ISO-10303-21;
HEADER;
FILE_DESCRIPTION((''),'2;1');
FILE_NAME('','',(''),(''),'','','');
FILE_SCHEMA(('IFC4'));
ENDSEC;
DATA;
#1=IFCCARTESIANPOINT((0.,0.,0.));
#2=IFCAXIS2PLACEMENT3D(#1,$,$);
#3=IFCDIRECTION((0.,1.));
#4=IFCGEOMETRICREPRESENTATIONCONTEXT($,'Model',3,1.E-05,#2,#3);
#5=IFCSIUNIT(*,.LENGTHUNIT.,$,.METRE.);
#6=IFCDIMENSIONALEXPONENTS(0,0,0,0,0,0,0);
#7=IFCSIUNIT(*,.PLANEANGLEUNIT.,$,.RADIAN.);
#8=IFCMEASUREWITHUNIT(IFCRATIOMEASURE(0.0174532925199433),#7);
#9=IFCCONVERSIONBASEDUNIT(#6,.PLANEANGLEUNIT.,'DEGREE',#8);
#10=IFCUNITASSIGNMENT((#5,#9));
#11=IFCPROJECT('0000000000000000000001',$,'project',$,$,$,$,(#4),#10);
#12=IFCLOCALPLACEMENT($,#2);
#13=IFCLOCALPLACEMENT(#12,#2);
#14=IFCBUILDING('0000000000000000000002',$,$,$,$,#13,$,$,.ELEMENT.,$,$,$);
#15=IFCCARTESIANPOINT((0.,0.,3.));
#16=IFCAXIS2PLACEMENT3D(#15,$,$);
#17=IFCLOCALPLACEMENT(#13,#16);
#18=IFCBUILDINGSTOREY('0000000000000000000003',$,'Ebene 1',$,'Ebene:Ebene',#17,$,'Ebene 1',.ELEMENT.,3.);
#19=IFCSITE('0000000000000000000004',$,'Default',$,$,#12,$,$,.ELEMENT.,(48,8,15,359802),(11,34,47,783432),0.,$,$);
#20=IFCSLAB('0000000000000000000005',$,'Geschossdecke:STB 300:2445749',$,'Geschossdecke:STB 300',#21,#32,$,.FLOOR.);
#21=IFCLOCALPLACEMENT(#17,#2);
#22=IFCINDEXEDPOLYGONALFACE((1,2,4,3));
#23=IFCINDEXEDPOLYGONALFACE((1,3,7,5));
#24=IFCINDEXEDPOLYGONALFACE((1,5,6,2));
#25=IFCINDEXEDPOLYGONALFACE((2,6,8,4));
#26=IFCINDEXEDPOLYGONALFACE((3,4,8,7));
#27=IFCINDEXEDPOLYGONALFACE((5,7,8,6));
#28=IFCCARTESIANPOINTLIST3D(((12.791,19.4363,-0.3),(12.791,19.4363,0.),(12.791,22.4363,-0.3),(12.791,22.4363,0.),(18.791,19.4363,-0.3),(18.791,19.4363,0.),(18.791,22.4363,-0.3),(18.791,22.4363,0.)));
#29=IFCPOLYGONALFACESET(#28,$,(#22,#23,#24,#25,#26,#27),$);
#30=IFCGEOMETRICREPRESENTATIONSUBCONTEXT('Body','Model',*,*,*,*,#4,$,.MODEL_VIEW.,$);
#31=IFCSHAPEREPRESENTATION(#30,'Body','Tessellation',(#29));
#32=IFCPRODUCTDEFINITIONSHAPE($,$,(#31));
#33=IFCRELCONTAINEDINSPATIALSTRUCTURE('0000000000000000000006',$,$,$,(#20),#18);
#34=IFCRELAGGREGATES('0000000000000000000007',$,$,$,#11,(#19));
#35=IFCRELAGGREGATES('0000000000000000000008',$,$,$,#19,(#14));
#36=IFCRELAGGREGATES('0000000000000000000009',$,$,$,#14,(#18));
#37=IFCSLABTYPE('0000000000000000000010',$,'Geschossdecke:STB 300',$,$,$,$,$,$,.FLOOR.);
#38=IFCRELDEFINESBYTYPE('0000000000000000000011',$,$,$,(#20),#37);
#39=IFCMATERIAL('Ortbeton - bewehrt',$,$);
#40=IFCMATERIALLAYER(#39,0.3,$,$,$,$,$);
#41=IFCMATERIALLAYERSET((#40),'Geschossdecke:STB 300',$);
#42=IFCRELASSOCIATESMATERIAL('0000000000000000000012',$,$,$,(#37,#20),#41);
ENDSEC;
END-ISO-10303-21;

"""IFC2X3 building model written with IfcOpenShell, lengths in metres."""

from ifc_helpers import new_model, entity, si_unit, converted_unit, direction, frame, frame_2d, origin, place, context, subcontext, project, spatial, rectangle, extrude, material, layer, layer_set, layer_usage, type_object, element, save


model = new_model("IFC2X3")

# Units and contexts
model_context = context("Model", 3, precision=1e-05, world=origin(), true_north=direction((0.0, 1.0)))
body_context = subcontext(model_context, "Body", "Model", "MODEL_VIEW")
ifc_project = project(units=[si_unit("LENGTHUNIT", "METRE"), converted_unit("PLANEANGLEUNIT", "DEGREE", entity("IfcRatioMeasure", 0.0174532925199433), si_unit("PLANEANGLEUNIT", "RADIAN"), dimensions=[0, 0, 0, 0, 0, 0, 0])], contexts=[model_context])

# Site, building, storey
site_placement = place(None, origin())
site = spatial("IfcSite", under=ifc_project, at=site_placement, Name="Default", CompositionType="ELEMENT", RefLatitude=(48, 8, 15, 359802), RefLongitude=(11, 34, 47, 783432), RefElevation=0.0)
building_placement = place(site_placement, origin())
building = spatial("IfcBuilding", under=site, at=building_placement, CompositionType="ELEMENT")
storey_placement = place(building_placement, frame((0.0, 0.0, 3.0)))
storey = spatial("IfcBuildingStorey", under=building, at=storey_placement, Name="Ebene 1", ObjectType="Ebene:Ebene", LongName="Ebene 1", CompositionType="ELEMENT", Elevation=3.0)

# Slab
ifc_material = material(Name="Ortbeton - bewehrt")
ifc_layer = layer(ifc_material, 0.3)
ifc_layer_set = layer_set([ifc_layer], Name="Geschossdecke:STB 300")
ifc_layer_usage = layer_usage(ifc_layer_set, "AXIS3", "POSITIVE", 0.0)
slab_type = type_object("IfcSlabType", Name="Geschossdecke:STB 300", PredefinedType="FLOOR", material=ifc_layer_set)
slab_placement = place(storey_placement, origin())
element("IfcSlab", 1, at=slab_placement, inside=storey, type_object=slab_type, material=ifc_layer_usage, Name="Geschossdecke:STB 300:2445749", ObjectType="Geschossdecke:STB 300", PredefinedType="FLOOR", context=body_context, shape_type="SweptSolid", body=[
    extrude(rectangle(XDim=3.0, YDim=6.0, at=frame_2d((0.0, 0.0), x_axis=(1.0, 0.0))), frame((15.791, 20.9363, 0.0), z_axis=(0.0, 0.0, -1.0), x_axis=(0.0, 1.0, 0.0)), (0.0, 0.0, 1.0), 0.3),
])

save(model, "model.ifc")
